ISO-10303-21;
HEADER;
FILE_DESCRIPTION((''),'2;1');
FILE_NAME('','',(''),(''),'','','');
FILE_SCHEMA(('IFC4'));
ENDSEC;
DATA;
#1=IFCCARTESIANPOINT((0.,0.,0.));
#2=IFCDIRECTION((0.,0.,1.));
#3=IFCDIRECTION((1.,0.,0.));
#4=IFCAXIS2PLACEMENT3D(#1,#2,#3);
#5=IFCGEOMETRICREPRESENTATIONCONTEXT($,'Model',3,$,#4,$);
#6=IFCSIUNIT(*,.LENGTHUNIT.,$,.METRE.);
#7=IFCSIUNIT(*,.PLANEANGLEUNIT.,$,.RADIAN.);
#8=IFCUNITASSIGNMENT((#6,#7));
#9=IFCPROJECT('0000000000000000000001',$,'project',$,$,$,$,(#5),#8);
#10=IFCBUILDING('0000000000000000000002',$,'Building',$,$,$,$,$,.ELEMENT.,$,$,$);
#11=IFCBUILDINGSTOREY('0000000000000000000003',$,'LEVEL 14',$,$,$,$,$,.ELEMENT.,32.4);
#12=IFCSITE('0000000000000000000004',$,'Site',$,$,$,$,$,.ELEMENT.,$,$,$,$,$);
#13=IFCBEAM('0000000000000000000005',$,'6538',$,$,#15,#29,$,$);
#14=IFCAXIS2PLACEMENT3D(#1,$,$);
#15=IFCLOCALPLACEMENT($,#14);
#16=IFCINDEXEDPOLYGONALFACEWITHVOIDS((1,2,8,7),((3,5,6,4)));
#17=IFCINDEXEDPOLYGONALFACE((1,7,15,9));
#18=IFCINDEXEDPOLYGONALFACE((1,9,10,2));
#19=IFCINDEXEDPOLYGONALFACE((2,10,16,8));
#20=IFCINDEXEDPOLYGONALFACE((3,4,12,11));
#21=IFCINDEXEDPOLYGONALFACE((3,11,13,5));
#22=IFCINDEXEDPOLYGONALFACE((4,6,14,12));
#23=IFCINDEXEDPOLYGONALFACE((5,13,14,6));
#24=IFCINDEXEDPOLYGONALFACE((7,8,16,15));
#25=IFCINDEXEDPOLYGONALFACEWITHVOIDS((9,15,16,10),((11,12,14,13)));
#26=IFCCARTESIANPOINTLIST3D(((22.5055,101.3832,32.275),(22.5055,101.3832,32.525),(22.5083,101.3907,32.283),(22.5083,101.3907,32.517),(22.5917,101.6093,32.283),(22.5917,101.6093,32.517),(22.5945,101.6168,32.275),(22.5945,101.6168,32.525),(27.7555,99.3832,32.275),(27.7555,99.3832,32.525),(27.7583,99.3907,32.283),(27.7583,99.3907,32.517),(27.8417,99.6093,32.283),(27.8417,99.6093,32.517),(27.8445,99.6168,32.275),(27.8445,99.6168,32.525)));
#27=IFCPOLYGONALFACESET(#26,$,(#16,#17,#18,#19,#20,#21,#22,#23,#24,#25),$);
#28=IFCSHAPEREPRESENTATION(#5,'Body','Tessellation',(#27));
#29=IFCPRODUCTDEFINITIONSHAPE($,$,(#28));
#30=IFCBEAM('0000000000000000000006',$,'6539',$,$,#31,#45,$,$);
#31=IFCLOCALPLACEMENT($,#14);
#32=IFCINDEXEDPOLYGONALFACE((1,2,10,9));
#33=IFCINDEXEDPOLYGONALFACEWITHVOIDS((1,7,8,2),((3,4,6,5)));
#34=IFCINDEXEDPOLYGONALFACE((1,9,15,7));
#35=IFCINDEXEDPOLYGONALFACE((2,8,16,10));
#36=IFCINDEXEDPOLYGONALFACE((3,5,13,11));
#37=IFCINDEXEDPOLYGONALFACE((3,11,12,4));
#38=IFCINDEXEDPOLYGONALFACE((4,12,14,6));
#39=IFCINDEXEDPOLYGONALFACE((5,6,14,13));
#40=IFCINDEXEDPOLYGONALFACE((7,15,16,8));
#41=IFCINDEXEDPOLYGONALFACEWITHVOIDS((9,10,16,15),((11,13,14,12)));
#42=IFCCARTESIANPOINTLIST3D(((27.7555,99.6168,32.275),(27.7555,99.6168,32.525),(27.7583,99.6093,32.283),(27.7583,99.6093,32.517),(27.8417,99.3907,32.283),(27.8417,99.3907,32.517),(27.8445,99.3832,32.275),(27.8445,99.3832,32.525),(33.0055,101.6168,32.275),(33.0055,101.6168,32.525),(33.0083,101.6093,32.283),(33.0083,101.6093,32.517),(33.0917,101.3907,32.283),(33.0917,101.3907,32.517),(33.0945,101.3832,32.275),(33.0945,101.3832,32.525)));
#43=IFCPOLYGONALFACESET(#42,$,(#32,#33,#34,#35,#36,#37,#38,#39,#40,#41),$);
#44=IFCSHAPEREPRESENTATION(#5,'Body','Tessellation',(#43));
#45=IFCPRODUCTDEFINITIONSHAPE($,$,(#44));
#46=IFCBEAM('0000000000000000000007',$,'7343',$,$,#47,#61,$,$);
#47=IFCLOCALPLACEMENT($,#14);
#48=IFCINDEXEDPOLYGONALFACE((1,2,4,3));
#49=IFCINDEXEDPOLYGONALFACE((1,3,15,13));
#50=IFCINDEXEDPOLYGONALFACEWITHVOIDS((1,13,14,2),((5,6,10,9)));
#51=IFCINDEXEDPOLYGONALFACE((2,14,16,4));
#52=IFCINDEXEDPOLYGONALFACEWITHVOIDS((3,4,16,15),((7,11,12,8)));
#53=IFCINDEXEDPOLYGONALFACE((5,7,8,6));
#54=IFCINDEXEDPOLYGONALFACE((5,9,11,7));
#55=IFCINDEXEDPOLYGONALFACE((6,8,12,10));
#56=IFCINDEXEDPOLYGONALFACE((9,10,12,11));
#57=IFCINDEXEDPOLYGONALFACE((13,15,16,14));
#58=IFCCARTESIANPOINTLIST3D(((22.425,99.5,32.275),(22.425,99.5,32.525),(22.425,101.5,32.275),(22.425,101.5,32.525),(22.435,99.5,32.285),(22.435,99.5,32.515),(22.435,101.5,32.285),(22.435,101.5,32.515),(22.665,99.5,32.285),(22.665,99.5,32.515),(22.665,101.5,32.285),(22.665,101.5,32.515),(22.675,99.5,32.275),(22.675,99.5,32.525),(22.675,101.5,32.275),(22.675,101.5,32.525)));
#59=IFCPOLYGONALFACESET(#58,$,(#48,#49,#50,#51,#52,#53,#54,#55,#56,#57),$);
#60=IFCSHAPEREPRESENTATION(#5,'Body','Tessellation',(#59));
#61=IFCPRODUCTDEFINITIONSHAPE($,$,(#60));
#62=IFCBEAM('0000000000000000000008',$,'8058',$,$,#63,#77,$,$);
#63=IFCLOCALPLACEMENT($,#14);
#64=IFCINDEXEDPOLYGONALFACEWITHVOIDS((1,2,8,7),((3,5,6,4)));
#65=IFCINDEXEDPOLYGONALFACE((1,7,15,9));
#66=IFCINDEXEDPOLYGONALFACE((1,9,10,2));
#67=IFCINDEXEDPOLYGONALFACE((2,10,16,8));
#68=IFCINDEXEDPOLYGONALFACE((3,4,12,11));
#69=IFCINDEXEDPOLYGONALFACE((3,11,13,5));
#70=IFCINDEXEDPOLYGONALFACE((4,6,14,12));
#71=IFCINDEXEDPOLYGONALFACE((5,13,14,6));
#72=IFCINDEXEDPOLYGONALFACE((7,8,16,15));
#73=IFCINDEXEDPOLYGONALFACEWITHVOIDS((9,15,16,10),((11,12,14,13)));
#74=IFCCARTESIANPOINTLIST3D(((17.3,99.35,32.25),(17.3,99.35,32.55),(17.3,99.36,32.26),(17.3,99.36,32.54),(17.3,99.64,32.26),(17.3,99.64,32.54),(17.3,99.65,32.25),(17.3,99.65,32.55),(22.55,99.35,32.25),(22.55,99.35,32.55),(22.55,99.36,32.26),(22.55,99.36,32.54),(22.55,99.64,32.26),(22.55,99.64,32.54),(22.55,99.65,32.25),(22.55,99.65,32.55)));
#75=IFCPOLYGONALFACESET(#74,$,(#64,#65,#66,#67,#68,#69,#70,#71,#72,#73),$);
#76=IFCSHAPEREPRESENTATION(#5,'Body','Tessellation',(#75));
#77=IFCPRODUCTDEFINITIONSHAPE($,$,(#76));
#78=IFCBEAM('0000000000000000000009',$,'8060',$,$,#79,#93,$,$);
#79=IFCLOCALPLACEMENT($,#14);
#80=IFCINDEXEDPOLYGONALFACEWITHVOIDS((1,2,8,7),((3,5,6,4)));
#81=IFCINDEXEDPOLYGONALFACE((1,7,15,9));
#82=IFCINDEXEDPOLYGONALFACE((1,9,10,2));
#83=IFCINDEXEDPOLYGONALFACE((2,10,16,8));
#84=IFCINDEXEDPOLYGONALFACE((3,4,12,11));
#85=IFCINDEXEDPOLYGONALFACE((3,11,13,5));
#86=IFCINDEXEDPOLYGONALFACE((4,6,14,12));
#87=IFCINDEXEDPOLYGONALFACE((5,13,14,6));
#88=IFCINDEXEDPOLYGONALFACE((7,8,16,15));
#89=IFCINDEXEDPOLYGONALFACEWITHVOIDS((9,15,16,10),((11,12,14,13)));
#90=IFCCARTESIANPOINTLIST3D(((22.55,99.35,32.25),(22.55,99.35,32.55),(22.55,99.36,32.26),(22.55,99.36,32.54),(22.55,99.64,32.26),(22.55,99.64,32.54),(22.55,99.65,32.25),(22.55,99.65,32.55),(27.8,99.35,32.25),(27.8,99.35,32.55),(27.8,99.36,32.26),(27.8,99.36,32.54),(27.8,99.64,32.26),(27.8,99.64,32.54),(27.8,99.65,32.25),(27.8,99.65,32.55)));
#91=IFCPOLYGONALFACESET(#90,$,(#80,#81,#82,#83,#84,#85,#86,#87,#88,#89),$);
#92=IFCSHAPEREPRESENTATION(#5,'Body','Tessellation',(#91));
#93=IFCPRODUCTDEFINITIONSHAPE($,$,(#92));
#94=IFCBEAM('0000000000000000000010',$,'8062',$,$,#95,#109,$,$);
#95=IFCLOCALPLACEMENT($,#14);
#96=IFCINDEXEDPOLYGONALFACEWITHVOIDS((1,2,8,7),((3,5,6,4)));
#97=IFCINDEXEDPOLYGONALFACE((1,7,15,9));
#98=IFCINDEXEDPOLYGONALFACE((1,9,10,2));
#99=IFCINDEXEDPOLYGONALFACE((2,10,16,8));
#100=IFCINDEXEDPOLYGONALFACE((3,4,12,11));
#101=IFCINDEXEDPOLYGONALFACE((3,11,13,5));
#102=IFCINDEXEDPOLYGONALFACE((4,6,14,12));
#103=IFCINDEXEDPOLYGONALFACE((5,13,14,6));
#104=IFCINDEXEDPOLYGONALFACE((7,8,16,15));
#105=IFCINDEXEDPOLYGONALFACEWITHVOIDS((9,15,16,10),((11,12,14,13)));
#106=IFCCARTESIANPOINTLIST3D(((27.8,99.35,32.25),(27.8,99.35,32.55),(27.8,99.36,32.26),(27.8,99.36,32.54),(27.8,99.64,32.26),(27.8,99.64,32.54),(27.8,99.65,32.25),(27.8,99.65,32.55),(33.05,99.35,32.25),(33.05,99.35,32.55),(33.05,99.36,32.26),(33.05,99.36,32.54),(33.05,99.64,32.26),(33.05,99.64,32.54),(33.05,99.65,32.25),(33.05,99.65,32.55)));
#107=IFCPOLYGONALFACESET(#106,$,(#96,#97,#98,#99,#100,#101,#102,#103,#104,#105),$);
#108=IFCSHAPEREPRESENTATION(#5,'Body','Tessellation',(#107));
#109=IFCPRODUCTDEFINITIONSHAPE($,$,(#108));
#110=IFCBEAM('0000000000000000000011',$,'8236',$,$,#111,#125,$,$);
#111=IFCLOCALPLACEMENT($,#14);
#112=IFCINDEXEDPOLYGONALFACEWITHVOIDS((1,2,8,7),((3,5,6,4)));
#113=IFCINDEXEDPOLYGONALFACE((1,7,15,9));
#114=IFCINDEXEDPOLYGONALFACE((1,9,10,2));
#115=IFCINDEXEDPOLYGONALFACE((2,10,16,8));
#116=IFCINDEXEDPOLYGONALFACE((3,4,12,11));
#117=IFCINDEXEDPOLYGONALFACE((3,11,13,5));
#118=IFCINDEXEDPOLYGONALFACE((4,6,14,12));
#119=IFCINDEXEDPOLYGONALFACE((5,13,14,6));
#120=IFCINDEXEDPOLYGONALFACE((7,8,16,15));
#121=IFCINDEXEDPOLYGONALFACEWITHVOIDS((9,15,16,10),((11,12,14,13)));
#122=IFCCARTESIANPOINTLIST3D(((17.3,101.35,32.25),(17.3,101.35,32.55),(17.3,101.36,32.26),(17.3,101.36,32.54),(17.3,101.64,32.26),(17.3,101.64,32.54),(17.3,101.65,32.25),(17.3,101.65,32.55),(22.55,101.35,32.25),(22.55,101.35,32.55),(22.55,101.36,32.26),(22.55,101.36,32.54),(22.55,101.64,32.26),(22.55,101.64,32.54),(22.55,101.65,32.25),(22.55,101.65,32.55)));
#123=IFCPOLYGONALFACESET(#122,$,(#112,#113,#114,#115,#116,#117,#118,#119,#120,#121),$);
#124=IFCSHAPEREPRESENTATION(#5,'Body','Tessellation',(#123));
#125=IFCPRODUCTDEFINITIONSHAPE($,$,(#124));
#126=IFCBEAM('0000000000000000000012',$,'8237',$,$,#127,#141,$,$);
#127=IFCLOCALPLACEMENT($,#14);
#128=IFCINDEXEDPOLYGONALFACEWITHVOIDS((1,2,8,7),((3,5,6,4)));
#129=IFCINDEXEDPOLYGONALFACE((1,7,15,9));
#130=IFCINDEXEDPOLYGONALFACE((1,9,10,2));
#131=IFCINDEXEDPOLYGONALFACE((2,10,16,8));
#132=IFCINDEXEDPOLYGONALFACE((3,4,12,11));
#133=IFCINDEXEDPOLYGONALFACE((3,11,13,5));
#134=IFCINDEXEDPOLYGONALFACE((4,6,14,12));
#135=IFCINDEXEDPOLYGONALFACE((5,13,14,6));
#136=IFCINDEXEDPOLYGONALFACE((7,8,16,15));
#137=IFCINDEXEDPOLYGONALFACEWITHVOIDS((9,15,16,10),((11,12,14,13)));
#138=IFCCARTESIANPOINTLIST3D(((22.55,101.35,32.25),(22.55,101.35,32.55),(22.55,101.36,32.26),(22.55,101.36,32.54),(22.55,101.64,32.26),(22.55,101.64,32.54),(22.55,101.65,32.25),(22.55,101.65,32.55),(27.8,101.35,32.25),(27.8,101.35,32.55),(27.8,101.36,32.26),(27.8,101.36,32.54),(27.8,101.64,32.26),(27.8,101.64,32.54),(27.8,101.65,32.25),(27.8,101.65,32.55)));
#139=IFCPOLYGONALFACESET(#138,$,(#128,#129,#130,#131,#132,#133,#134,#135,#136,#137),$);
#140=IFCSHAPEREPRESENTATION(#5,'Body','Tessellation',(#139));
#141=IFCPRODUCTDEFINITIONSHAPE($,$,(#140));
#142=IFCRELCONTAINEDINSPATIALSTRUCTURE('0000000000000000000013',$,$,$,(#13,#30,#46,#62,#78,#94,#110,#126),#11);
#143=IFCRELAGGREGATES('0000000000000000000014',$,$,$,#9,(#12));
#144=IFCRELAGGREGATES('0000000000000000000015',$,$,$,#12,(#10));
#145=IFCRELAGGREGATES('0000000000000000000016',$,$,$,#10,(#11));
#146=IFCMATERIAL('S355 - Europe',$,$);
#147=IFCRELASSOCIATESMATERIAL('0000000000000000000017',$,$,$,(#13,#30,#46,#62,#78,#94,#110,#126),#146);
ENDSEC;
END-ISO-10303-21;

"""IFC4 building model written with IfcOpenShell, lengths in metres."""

from ifc_helpers import new_model, si_unit, frame, origin_with_axes, origin_2d_with_axis, place, context, project, spatial, hollow_rectangle, extrude, material, material_profile, profile_set, profile_usage, element, save


model = new_model("IFC4")

# Units and contexts
model_context = context("Model", 3, world=origin_with_axes())
ifc_project = project(units=[si_unit("LENGTHUNIT", "METRE"), si_unit("PLANEANGLEUNIT", "RADIAN")], contexts=[model_context])

# Site, building, storey
site = spatial("IfcSite", under=ifc_project, Name="Site", CompositionType="ELEMENT")
building = spatial("IfcBuilding", under=site, Name="Building", CompositionType="ELEMENT")
storey = spatial("IfcBuildingStorey", under=building, Name="LEVEL 14", CompositionType="ELEMENT", Elevation=32.4)

# Shared definitions
ifc_material = material(Name="S355 - Europe")

# Beams
ifc_material_profile_1 = material_profile(ifc_material, hollow_rectangle(XDim=0.25, YDim=0.25, WallThickness=0.008, at=origin_2d_with_axis()))
ifc_profile_set_1 = profile_set([ifc_material_profile_1])
ifc_profile_usage_1 = profile_usage(ifc_profile_set_1, cardinal=10)
beam_1_placement = place(None, frame((22.55, 101.5, 32.4), z_axis=(0.934488, -0.355995, 0.0), x_axis=(0.355995, 0.934488, 0.0)))
element("IfcBeam", 1, at=beam_1_placement, inside=storey, material=ifc_profile_usage_1, Name="6538", context=model_context, shape_type="SweptSolid", body=[
    extrude(hollow_rectangle(XDim=0.25, YDim=0.25, WallThickness=0.008, at=origin_2d_with_axis()), origin_with_axes(), (0.0, 0.0, 1.0), 5.6181),
])
ifc_material_profile_2 = material_profile(ifc_material, hollow_rectangle(XDim=0.25, YDim=0.25, WallThickness=0.008, at=origin_2d_with_axis()))
ifc_profile_set_2 = profile_set([ifc_material_profile_2])
ifc_profile_usage_2 = profile_usage(ifc_profile_set_2, cardinal=10)
beam_2_placement = place(None, frame((27.8, 99.5, 32.4), z_axis=(0.934488, 0.355995, 0.0), x_axis=(-0.355995, 0.934488, 0.0)))
element("IfcBeam", 2, at=beam_2_placement, inside=storey, material=ifc_profile_usage_2, Name="6539", context=model_context, shape_type="SweptSolid", body=[
    extrude(hollow_rectangle(XDim=0.25, YDim=0.25, WallThickness=0.008, at=origin_2d_with_axis()), origin_with_axes(), (0.0, 0.0, 1.0), 5.6181),
])
ifc_material_profile_3 = material_profile(ifc_material, hollow_rectangle(XDim=0.25, YDim=0.25, WallThickness=0.01, at=origin_2d_with_axis()))
ifc_profile_set_3 = profile_set([ifc_material_profile_3])
ifc_profile_usage_3 = profile_usage(ifc_profile_set_3, cardinal=10)
beam_3_placement = place(None, frame((22.55, 101.5, 32.4), z_axis=(0.0, -1.0, 0.0), x_axis=(1.0, 0.0, 0.0)))
element("IfcBeam", 3, at=beam_3_placement, inside=storey, material=ifc_profile_usage_3, Name="7343", context=model_context, shape_type="SweptSolid", body=[
    extrude(hollow_rectangle(XDim=0.25, YDim=0.25, WallThickness=0.01, at=origin_2d_with_axis()), origin_with_axes(), (0.0, 0.0, 1.0), 2.0),
])
ifc_material_profile_4 = material_profile(ifc_material, hollow_rectangle(XDim=0.3, YDim=0.3, WallThickness=0.01, at=origin_2d_with_axis()))
ifc_profile_set_4 = profile_set([ifc_material_profile_4])
ifc_profile_usage_4 = profile_usage(ifc_profile_set_4, cardinal=10)
beam_4_placement = place(None, frame((17.3, 99.5, 32.4), z_axis=(1.0, 0.0, 0.0), x_axis=(0.0, 1.0, 0.0)))
element("IfcBeam", 4, at=beam_4_placement, inside=storey, material=ifc_profile_usage_4, Name="8058", context=model_context, shape_type="SweptSolid", body=[
    extrude(hollow_rectangle(XDim=0.3, YDim=0.3, WallThickness=0.01, at=origin_2d_with_axis()), origin_with_axes(), (0.0, 0.0, 1.0), 5.25),
])
ifc_material_profile_5 = material_profile(ifc_material, hollow_rectangle(XDim=0.3, YDim=0.3, WallThickness=0.01, at=origin_2d_with_axis()))
ifc_profile_set_5 = profile_set([ifc_material_profile_5])
ifc_profile_usage_5 = profile_usage(ifc_profile_set_5, cardinal=10)
beam_5_placement = place(None, frame((22.55, 99.5, 32.4), z_axis=(1.0, 0.0, 0.0), x_axis=(0.0, 1.0, 0.0)))
element("IfcBeam", 5, at=beam_5_placement, inside=storey, material=ifc_profile_usage_5, Name="8060", context=model_context, shape_type="SweptSolid", body=[
    extrude(hollow_rectangle(XDim=0.3, YDim=0.3, WallThickness=0.01, at=origin_2d_with_axis()), origin_with_axes(), (0.0, 0.0, 1.0), 5.25),
])
ifc_material_profile_6 = material_profile(ifc_material, hollow_rectangle(XDim=0.3, YDim=0.3, WallThickness=0.01, at=origin_2d_with_axis()))
ifc_profile_set_6 = profile_set([ifc_material_profile_6])
ifc_profile_usage_6 = profile_usage(ifc_profile_set_6, cardinal=10)
beam_6_placement = place(None, frame((27.8, 99.5, 32.4), z_axis=(1.0, 0.0, 0.0), x_axis=(0.0, 1.0, 0.0)))
element("IfcBeam", 6, at=beam_6_placement, inside=storey, material=ifc_profile_usage_6, Name="8062", context=model_context, shape_type="SweptSolid", body=[
    extrude(hollow_rectangle(XDim=0.3, YDim=0.3, WallThickness=0.01, at=origin_2d_with_axis()), origin_with_axes(), (0.0, 0.0, 1.0), 5.25),
])
ifc_material_profile_7 = material_profile(ifc_material, hollow_rectangle(XDim=0.3, YDim=0.3, WallThickness=0.01, at=origin_2d_with_axis()))
ifc_profile_set_7 = profile_set([ifc_material_profile_7])
ifc_profile_usage_7 = profile_usage(ifc_profile_set_7, cardinal=10)
beam_7_placement = place(None, frame((17.3, 101.5, 32.4), z_axis=(1.0, 0.0, 0.0), x_axis=(0.0, 1.0, 0.0)))
element("IfcBeam", 7, at=beam_7_placement, inside=storey, material=ifc_profile_usage_7, Name="8236", context=model_context, shape_type="SweptSolid", body=[
    extrude(hollow_rectangle(XDim=0.3, YDim=0.3, WallThickness=0.01, at=origin_2d_with_axis()), origin_with_axes(), (0.0, 0.0, 1.0), 5.25),
])
ifc_material_profile_8 = material_profile(ifc_material, hollow_rectangle(XDim=0.3, YDim=0.3, WallThickness=0.01, at=origin_2d_with_axis()))
ifc_profile_set_8 = profile_set([ifc_material_profile_8])
ifc_profile_usage_8 = profile_usage(ifc_profile_set_8, cardinal=10)
beam_8_placement = place(None, frame((22.55, 101.5, 32.4), z_axis=(1.0, 0.0, 0.0), x_axis=(0.0, 1.0, 0.0)))
element("IfcBeam", 8, at=beam_8_placement, inside=storey, material=ifc_profile_usage_8, Name="8237", context=model_context, shape_type="SweptSolid", body=[
    extrude(hollow_rectangle(XDim=0.3, YDim=0.3, WallThickness=0.01, at=origin_2d_with_axis()), origin_with_axes(), (0.0, 0.0, 1.0), 5.25),
])

save(model, "model.ifc")
